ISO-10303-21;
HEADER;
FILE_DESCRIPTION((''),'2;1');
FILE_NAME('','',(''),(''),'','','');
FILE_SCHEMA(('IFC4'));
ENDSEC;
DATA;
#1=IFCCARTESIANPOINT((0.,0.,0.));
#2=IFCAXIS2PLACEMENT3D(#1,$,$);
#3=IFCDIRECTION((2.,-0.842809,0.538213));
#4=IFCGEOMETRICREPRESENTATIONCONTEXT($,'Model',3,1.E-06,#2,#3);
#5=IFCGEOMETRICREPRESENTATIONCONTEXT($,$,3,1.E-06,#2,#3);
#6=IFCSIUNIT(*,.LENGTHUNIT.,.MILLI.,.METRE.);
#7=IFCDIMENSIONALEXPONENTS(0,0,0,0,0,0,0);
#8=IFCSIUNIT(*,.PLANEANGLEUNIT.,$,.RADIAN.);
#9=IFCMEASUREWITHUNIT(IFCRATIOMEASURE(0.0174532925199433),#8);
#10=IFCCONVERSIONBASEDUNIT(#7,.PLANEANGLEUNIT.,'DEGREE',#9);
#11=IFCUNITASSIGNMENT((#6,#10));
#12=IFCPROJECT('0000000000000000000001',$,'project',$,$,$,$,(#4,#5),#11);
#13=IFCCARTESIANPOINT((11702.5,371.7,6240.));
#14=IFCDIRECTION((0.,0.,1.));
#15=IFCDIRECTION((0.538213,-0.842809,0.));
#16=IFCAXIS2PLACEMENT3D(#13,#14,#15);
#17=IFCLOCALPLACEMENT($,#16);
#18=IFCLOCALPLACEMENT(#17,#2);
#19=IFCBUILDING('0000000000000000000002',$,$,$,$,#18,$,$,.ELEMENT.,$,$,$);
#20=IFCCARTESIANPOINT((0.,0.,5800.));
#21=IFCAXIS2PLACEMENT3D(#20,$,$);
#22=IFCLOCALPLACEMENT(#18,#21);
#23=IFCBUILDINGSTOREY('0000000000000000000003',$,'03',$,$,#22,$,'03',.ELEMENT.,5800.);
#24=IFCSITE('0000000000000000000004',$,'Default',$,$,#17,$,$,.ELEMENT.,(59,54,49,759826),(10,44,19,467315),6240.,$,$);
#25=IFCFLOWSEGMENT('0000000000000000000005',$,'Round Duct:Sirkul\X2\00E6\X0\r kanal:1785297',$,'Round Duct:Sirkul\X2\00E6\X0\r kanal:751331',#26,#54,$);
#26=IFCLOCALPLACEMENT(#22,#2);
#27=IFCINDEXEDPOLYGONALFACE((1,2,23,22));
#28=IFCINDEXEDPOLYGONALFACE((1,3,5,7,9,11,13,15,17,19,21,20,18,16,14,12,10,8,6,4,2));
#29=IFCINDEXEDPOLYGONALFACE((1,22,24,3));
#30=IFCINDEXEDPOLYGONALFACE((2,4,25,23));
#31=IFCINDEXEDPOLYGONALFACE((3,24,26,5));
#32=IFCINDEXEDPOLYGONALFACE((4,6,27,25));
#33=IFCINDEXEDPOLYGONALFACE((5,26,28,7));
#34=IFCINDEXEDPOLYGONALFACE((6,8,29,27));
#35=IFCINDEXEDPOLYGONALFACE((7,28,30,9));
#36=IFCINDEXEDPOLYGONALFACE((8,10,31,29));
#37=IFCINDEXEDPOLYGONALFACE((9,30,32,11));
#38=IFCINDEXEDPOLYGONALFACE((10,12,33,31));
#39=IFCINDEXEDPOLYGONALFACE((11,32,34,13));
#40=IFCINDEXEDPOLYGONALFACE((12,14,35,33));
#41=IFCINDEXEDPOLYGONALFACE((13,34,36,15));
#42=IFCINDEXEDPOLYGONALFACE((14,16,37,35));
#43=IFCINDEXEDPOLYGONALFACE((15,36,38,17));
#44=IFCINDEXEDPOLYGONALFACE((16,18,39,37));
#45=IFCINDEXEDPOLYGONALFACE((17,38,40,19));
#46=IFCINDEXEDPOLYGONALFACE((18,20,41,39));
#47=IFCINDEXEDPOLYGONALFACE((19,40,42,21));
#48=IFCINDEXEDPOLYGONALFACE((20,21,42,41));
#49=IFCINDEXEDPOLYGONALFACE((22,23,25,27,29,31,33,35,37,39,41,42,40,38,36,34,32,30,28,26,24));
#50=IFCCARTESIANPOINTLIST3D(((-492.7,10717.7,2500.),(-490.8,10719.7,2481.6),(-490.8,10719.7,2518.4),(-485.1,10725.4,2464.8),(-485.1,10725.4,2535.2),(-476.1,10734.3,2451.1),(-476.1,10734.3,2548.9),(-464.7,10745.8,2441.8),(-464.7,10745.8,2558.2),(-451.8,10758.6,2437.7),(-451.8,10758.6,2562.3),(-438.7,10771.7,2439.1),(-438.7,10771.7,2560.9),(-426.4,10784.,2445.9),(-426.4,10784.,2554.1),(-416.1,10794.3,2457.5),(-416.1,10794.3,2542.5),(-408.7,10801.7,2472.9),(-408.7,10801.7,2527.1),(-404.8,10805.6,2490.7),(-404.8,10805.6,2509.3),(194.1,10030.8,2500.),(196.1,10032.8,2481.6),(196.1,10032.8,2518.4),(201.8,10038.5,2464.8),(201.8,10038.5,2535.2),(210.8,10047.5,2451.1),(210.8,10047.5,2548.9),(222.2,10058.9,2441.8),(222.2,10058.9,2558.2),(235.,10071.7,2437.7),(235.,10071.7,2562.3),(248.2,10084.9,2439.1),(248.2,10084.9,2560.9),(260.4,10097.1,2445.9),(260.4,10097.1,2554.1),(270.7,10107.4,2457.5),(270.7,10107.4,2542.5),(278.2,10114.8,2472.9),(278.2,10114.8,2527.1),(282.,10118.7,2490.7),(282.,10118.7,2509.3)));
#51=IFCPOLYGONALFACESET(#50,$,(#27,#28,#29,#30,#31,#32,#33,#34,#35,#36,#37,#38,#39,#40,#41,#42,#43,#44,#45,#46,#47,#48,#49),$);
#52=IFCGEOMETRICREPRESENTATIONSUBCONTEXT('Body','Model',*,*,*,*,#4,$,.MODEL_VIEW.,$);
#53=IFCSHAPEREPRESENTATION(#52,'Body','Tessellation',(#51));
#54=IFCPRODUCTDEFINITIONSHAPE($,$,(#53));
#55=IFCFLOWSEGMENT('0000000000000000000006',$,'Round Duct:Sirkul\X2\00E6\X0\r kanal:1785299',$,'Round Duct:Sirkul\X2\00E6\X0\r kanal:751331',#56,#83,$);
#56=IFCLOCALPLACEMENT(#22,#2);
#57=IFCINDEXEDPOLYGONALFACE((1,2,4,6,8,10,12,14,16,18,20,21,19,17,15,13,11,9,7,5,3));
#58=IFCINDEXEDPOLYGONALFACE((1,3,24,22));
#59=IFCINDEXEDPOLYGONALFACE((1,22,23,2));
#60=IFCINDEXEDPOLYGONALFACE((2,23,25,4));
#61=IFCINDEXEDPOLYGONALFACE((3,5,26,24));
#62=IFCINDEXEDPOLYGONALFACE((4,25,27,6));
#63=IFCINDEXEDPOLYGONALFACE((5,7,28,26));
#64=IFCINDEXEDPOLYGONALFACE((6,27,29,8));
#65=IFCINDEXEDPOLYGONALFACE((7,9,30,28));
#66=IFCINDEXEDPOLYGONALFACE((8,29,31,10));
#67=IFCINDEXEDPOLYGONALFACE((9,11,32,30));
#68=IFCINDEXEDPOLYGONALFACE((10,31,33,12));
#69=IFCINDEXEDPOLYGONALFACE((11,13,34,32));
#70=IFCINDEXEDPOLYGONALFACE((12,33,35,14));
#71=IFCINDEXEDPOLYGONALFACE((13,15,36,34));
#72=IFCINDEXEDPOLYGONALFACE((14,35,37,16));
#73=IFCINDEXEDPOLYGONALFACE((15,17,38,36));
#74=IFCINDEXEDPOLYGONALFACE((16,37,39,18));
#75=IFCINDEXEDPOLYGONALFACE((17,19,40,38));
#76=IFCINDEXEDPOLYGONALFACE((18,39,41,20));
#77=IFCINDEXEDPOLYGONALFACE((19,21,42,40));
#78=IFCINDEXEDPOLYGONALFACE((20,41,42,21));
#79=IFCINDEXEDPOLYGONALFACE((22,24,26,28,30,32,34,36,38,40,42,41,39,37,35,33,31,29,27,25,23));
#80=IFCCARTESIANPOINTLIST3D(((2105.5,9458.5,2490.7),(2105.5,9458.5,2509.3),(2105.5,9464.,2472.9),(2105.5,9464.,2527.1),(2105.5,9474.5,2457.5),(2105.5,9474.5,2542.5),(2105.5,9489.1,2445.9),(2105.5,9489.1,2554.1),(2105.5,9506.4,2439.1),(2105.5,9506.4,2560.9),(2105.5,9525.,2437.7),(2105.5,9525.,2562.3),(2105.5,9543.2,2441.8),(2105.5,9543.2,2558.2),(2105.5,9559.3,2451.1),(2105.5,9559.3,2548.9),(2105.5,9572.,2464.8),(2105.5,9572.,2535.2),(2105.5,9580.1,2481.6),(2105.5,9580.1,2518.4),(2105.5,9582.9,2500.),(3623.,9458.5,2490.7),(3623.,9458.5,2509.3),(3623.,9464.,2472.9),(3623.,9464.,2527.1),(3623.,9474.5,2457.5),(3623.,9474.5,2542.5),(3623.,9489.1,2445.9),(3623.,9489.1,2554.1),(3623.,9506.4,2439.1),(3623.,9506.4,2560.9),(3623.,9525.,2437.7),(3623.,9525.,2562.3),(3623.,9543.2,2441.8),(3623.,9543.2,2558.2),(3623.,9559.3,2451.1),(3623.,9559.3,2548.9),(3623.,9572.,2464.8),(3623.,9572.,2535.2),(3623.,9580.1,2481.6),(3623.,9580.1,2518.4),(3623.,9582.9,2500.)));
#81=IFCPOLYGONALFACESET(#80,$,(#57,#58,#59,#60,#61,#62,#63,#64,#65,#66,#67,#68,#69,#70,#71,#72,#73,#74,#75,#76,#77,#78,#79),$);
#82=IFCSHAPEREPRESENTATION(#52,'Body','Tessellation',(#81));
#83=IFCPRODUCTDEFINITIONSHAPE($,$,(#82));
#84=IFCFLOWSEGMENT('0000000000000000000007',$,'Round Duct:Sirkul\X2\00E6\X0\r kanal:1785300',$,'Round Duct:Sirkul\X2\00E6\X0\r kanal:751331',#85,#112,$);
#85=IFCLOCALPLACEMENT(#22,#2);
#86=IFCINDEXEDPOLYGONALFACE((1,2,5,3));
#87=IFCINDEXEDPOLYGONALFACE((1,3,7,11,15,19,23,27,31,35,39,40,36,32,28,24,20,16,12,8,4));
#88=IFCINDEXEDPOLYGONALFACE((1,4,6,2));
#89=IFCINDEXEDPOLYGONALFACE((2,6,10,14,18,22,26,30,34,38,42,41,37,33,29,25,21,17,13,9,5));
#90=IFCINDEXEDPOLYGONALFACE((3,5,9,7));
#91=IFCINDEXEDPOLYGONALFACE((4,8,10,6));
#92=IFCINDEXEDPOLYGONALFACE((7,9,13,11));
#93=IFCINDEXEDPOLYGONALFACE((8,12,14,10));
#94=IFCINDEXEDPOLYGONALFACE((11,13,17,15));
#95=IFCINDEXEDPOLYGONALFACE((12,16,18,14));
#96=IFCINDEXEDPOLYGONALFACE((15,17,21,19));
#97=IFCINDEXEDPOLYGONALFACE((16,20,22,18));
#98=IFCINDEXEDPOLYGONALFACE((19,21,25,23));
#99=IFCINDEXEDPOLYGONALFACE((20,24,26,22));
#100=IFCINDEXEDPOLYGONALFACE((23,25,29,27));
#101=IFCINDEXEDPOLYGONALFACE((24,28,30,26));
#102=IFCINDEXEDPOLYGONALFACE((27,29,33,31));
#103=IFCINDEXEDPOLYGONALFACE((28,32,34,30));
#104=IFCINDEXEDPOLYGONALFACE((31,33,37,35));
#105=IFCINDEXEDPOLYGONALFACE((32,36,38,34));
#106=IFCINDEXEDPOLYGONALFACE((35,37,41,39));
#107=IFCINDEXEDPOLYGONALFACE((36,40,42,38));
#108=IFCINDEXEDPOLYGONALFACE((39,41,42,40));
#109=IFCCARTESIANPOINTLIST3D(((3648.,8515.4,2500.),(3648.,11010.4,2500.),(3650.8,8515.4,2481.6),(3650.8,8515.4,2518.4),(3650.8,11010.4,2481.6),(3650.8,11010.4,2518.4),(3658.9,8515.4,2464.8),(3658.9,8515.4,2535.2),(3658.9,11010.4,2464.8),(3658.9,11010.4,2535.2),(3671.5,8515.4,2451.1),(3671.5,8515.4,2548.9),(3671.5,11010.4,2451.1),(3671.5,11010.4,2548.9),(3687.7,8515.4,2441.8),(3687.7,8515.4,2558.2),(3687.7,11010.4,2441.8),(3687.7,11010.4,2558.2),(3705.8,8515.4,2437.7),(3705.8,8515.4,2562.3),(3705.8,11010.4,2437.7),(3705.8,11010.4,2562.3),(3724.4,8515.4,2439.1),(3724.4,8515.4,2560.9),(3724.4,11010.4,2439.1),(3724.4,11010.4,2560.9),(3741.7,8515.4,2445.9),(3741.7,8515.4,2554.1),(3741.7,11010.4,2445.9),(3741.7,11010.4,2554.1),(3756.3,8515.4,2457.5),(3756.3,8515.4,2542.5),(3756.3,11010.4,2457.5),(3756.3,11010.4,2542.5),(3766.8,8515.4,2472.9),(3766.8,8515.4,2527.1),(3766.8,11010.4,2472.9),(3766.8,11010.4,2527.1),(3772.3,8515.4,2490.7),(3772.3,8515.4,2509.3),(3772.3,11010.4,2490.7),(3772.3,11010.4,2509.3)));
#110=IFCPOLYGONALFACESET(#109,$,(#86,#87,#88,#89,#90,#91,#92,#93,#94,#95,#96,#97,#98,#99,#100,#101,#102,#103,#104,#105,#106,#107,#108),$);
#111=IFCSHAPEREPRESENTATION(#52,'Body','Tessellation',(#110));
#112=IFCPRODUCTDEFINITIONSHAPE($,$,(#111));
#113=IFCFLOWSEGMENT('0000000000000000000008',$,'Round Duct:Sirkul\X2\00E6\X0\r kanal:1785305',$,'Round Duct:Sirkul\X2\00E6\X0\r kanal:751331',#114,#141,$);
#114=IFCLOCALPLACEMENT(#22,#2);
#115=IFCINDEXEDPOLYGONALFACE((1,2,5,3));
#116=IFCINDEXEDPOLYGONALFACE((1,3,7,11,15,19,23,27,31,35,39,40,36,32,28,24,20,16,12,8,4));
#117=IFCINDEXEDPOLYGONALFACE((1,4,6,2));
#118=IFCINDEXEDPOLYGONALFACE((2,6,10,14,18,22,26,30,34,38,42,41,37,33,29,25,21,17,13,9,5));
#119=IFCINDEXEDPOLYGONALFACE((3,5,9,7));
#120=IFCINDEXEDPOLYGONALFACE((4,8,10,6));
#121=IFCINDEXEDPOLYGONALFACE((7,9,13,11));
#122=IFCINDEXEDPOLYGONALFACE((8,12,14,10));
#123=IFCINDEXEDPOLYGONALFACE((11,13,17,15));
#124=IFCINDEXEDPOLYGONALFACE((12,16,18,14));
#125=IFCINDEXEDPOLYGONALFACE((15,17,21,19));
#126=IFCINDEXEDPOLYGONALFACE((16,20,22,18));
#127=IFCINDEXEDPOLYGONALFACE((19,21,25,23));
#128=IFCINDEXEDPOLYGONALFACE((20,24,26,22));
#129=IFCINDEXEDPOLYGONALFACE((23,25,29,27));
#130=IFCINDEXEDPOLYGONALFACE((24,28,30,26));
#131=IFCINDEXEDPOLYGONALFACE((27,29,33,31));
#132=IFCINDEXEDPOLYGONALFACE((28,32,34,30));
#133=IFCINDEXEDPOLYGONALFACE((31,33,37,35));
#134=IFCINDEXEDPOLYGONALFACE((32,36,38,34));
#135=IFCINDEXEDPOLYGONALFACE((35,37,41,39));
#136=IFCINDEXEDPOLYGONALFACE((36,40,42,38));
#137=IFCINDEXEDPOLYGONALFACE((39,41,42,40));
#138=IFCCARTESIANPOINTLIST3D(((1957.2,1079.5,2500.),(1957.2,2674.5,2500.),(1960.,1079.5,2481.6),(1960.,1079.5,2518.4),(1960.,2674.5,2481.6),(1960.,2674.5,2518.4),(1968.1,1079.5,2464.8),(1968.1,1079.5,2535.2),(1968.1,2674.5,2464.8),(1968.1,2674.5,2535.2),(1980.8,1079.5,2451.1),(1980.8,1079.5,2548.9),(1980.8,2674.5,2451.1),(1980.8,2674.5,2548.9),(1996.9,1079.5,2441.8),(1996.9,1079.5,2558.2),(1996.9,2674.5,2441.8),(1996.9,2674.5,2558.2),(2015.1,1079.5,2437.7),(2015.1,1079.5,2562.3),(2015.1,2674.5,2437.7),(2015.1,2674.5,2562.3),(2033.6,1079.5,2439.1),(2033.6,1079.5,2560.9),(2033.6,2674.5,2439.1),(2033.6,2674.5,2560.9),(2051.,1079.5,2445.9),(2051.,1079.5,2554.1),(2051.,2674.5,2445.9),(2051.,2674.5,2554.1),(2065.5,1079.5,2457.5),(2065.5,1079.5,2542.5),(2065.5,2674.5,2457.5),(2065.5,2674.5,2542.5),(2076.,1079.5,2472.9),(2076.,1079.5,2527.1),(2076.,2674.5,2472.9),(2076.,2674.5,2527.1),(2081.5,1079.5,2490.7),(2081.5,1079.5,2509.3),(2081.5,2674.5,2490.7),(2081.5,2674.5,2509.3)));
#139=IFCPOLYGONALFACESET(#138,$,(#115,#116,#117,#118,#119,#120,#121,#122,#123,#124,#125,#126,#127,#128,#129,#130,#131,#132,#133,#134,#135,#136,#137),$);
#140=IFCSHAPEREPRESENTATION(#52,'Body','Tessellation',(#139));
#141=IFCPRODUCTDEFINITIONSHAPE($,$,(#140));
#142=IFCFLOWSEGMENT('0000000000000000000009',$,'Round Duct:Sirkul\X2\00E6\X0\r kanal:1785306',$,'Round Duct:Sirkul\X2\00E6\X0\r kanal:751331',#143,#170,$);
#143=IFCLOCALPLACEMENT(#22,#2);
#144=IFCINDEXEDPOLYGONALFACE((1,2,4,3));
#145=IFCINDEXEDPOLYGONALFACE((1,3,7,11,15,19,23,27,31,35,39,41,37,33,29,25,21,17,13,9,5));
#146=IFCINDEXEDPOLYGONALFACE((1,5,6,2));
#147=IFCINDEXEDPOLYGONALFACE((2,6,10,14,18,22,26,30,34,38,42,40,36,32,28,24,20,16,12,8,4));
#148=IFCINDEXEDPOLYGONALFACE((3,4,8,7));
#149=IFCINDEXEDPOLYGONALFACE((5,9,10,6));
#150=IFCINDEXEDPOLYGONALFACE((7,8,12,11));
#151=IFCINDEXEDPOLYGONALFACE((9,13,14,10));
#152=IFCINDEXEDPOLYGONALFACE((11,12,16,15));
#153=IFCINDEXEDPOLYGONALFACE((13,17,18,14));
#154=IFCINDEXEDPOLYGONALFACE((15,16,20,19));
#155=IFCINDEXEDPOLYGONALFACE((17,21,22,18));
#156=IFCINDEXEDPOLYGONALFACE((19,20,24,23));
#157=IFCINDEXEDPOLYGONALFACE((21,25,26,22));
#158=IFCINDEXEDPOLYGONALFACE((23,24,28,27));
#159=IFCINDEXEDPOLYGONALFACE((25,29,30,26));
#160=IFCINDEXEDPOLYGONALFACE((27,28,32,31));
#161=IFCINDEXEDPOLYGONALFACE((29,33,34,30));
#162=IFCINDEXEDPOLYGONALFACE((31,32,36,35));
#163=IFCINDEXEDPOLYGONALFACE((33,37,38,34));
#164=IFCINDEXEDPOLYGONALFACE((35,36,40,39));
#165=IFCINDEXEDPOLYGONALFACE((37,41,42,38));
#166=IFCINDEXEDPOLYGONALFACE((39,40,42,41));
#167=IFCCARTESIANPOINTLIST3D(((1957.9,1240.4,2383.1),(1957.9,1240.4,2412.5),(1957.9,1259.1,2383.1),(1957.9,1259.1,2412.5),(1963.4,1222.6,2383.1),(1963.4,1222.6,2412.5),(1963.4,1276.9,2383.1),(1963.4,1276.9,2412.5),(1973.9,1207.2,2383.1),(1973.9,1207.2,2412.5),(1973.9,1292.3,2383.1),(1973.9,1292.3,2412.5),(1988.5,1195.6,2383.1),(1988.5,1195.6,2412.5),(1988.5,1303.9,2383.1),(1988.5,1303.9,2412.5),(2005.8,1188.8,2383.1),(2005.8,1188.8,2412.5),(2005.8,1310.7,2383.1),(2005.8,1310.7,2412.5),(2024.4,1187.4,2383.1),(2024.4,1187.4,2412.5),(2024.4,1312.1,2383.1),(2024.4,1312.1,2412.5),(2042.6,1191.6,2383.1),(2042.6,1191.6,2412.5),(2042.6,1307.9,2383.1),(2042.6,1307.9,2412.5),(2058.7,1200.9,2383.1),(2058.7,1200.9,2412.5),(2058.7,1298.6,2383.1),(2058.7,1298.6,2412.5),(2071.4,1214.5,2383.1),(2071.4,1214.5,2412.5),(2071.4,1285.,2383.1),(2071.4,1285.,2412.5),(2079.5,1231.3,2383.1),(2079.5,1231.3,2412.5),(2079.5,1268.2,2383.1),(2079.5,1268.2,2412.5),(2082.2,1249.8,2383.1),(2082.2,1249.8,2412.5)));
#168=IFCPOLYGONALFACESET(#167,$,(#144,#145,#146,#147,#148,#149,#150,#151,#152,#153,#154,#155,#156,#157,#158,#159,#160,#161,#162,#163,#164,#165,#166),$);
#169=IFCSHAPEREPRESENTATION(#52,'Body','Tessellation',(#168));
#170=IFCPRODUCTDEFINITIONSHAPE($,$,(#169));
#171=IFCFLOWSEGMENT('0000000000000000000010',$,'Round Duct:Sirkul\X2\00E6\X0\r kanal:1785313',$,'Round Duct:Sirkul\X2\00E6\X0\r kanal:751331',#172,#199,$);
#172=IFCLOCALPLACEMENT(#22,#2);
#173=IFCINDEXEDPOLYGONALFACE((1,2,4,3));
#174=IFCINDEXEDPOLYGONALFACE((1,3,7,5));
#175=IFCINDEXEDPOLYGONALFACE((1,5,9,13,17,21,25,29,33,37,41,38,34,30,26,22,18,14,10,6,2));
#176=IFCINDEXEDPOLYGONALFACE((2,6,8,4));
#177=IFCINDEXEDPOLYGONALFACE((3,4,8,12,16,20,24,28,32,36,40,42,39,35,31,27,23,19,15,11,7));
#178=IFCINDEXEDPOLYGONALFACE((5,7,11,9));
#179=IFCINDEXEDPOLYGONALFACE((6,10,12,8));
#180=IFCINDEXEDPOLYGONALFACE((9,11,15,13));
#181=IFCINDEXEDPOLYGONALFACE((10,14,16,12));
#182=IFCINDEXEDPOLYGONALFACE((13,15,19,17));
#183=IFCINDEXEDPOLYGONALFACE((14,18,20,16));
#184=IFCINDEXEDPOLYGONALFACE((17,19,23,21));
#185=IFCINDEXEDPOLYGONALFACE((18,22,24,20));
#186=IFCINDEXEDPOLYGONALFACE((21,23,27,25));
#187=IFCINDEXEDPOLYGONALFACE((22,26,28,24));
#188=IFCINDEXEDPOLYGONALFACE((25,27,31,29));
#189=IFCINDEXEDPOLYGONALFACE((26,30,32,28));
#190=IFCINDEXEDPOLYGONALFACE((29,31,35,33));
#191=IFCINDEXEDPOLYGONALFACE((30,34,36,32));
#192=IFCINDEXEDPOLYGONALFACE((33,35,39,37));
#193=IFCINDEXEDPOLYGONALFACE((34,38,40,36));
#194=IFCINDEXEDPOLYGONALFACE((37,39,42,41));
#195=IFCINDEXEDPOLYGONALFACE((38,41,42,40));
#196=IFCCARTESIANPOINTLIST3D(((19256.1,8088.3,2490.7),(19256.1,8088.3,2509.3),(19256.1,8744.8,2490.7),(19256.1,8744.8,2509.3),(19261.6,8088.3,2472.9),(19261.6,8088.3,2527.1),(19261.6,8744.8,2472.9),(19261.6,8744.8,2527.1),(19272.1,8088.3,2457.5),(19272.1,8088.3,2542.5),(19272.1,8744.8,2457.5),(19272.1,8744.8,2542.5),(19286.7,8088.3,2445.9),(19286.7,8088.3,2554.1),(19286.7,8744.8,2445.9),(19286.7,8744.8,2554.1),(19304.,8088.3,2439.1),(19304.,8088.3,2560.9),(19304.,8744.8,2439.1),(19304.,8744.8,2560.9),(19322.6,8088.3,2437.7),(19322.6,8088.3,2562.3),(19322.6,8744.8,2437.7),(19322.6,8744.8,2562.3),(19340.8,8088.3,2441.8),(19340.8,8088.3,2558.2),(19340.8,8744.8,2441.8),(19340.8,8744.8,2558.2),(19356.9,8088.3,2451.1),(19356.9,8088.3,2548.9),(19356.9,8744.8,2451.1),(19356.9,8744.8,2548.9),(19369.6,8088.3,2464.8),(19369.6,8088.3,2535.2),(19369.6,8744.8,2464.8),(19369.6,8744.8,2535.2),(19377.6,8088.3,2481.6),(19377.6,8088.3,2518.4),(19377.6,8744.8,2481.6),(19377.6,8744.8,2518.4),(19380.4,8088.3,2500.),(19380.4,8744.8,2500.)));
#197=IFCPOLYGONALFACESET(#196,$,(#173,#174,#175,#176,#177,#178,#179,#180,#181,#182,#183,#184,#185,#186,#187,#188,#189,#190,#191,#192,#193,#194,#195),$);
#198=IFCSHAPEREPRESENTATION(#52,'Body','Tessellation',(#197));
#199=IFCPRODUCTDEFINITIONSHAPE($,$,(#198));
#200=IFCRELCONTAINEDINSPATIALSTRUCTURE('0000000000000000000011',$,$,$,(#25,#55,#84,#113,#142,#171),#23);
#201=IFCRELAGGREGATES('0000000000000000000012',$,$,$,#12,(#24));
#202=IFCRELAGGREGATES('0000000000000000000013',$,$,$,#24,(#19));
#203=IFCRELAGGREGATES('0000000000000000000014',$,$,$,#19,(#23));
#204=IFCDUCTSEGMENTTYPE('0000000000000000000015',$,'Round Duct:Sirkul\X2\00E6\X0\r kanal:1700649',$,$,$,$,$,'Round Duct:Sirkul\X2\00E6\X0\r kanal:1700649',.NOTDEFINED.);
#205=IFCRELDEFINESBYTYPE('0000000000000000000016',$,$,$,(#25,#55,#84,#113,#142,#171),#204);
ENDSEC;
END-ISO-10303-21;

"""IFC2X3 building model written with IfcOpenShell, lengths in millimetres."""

from ifc_helpers import new_model, entity, si_unit, converted_unit, direction, frame, frame_2d, origin, place, context, subcontext, project, spatial, circle, extrude, type_object, element, save


model = new_model("IFC2X3")

# Units and contexts
model_context = context("Model", 3, precision=1e-06, world=origin(), true_north=direction((2.0, -0.842809, 0.538213)))
context_of_model = context(None, 3, precision=1e-06, world=origin(), true_north=direction((2.0, -0.842809, 0.538213)))
body_context = subcontext(model_context, "Body", "Model", "MODEL_VIEW")
ifc_project = project(units=[si_unit("LENGTHUNIT", "METRE", prefix="MILLI"), converted_unit("PLANEANGLEUNIT", "DEGREE", entity("IfcRatioMeasure", 0.0174532925199433), si_unit("PLANEANGLEUNIT", "RADIAN"), dimensions=[0, 0, 0, 0, 0, 0, 0])], contexts=[model_context, context_of_model])

# Site, building, storey
site_placement = place(None, frame((11702.5, 371.7, 6240.0), z_axis=(0.0, 0.0, 1.0), x_axis=(0.538213, -0.842809, 0.0)))
site = spatial("IfcSite", under=ifc_project, at=site_placement, Name="Default", CompositionType="ELEMENT", RefLatitude=(59, 54, 49, 759826), RefLongitude=(10, 44, 19, 467315), RefElevation=6240.0)
building_placement = place(site_placement, origin())
building = spatial("IfcBuilding", under=site, at=building_placement, CompositionType="ELEMENT")
storey_placement = place(building_placement, frame((0.0, 0.0, 5800.0)))
storey = spatial("IfcBuildingStorey", under=building, at=storey_placement, Name="03", LongName="03", CompositionType="ELEMENT", Elevation=5800.0)

# Flow segments
duct_segment_type = type_object("IfcDuctSegmentType", Name="Round Duct:Sirkulær kanal:1700649", ElementType="Round Duct:Sirkulær kanal:1700649", PredefinedType="NOTDEFINED")
flow_segment_1_placement = place(storey_placement, origin())
element("IfcFlowSegment", 1, at=flow_segment_1_placement, inside=storey, type_object=duct_segment_type, Name="Round Duct:Sirkulær kanal:1785297", ObjectType="Round Duct:Sirkulær kanal:751331", context=body_context, shape_type="SweptSolid", body=[
    extrude(circle(Radius=62.5, at=frame_2d((0.0, 0.0), x_axis=(1.0, 0.0))), frame((238.3, 10075.0, 2500.0), z_axis=(-0.707107, 0.707107, 0.0), x_axis=(-0.707107, -0.707107, 0.0)), (0.0, 0.0, 1.0), 971.4),
])
flow_segment_2_placement = place(storey_placement, origin())
element("IfcFlowSegment", 2, at=flow_segment_2_placement, inside=storey, type_object=duct_segment_type, Name="Round Duct:Sirkulær kanal:1785299", ObjectType="Round Duct:Sirkulær kanal:751331", context=body_context, shape_type="SweptSolid", body=[
    extrude(circle(Radius=62.5, at=frame_2d((0.0, 0.0), x_axis=(1.0, 0.0))), frame((2105.5, 9520.4, 2500.0), z_axis=(1.0, 0.0, 0.0), x_axis=(0.0, 1.0, 0.0)), (0.0, 0.0, 1.0), 1517.5),
])
flow_segment_3_placement = place(storey_placement, origin())
element("IfcFlowSegment", 3, at=flow_segment_3_placement, inside=storey, type_object=duct_segment_type, Name="Round Duct:Sirkulær kanal:1785300", ObjectType="Round Duct:Sirkulær kanal:751331", context=body_context, shape_type="SweptSolid", body=[
    extrude(circle(Radius=62.5, at=frame_2d((0.0, 0.0), x_axis=(1.0, 0.0))), frame((3710.5, 8515.4, 2500.0), z_axis=(0.0, 1.0, 0.0), x_axis=(-1.0, 0.0, 0.0)), (0.0, 0.0, 1.0), 2495.0),
])
flow_segment_4_placement = place(storey_placement, origin())
element("IfcFlowSegment", 4, at=flow_segment_4_placement, inside=storey, type_object=duct_segment_type, Name="Round Duct:Sirkulær kanal:1785305", ObjectType="Round Duct:Sirkulær kanal:751331", context=body_context, shape_type="SweptSolid", body=[
    extrude(circle(Radius=62.5, at=frame_2d((0.0, 0.0), x_axis=(1.0, 0.0))), frame((2019.7, 1079.5, 2500.0), z_axis=(0.0, 1.0, 0.0), x_axis=(-1.0, 0.0, 0.0)), (0.0, 0.0, 1.0), 1595.0),
])
flow_segment_5_placement = place(storey_placement, origin())
element("IfcFlowSegment", 5, at=flow_segment_5_placement, inside=storey, type_object=duct_segment_type, Name="Round Duct:Sirkulær kanal:1785306", ObjectType="Round Duct:Sirkulær kanal:751331", context=body_context, shape_type="SweptSolid", body=[
    extrude(circle(Radius=62.5, at=frame_2d((0.0, 0.0), x_axis=(1.0, 0.0))), frame((2019.7, 1249.8, 2383.1)), (0.0, 0.0, 1.0), 29.4),
])
flow_segment_6_placement = place(storey_placement, origin())
element("IfcFlowSegment", 6, at=flow_segment_6_placement, inside=storey, type_object=duct_segment_type, Name="Round Duct:Sirkulær kanal:1785313", ObjectType="Round Duct:Sirkulær kanal:751331", context=body_context, shape_type="SweptSolid", body=[
    extrude(circle(Radius=62.5, at=frame_2d((0.0, 0.0), x_axis=(1.0, 0.0))), frame((19317.9, 8088.3, 2500.0), z_axis=(0.0, 1.0, 0.0), x_axis=(1.0, 0.0, 0.0)), (0.0, 0.0, 1.0), 656.5),
])

save(model, "model.ifc")
